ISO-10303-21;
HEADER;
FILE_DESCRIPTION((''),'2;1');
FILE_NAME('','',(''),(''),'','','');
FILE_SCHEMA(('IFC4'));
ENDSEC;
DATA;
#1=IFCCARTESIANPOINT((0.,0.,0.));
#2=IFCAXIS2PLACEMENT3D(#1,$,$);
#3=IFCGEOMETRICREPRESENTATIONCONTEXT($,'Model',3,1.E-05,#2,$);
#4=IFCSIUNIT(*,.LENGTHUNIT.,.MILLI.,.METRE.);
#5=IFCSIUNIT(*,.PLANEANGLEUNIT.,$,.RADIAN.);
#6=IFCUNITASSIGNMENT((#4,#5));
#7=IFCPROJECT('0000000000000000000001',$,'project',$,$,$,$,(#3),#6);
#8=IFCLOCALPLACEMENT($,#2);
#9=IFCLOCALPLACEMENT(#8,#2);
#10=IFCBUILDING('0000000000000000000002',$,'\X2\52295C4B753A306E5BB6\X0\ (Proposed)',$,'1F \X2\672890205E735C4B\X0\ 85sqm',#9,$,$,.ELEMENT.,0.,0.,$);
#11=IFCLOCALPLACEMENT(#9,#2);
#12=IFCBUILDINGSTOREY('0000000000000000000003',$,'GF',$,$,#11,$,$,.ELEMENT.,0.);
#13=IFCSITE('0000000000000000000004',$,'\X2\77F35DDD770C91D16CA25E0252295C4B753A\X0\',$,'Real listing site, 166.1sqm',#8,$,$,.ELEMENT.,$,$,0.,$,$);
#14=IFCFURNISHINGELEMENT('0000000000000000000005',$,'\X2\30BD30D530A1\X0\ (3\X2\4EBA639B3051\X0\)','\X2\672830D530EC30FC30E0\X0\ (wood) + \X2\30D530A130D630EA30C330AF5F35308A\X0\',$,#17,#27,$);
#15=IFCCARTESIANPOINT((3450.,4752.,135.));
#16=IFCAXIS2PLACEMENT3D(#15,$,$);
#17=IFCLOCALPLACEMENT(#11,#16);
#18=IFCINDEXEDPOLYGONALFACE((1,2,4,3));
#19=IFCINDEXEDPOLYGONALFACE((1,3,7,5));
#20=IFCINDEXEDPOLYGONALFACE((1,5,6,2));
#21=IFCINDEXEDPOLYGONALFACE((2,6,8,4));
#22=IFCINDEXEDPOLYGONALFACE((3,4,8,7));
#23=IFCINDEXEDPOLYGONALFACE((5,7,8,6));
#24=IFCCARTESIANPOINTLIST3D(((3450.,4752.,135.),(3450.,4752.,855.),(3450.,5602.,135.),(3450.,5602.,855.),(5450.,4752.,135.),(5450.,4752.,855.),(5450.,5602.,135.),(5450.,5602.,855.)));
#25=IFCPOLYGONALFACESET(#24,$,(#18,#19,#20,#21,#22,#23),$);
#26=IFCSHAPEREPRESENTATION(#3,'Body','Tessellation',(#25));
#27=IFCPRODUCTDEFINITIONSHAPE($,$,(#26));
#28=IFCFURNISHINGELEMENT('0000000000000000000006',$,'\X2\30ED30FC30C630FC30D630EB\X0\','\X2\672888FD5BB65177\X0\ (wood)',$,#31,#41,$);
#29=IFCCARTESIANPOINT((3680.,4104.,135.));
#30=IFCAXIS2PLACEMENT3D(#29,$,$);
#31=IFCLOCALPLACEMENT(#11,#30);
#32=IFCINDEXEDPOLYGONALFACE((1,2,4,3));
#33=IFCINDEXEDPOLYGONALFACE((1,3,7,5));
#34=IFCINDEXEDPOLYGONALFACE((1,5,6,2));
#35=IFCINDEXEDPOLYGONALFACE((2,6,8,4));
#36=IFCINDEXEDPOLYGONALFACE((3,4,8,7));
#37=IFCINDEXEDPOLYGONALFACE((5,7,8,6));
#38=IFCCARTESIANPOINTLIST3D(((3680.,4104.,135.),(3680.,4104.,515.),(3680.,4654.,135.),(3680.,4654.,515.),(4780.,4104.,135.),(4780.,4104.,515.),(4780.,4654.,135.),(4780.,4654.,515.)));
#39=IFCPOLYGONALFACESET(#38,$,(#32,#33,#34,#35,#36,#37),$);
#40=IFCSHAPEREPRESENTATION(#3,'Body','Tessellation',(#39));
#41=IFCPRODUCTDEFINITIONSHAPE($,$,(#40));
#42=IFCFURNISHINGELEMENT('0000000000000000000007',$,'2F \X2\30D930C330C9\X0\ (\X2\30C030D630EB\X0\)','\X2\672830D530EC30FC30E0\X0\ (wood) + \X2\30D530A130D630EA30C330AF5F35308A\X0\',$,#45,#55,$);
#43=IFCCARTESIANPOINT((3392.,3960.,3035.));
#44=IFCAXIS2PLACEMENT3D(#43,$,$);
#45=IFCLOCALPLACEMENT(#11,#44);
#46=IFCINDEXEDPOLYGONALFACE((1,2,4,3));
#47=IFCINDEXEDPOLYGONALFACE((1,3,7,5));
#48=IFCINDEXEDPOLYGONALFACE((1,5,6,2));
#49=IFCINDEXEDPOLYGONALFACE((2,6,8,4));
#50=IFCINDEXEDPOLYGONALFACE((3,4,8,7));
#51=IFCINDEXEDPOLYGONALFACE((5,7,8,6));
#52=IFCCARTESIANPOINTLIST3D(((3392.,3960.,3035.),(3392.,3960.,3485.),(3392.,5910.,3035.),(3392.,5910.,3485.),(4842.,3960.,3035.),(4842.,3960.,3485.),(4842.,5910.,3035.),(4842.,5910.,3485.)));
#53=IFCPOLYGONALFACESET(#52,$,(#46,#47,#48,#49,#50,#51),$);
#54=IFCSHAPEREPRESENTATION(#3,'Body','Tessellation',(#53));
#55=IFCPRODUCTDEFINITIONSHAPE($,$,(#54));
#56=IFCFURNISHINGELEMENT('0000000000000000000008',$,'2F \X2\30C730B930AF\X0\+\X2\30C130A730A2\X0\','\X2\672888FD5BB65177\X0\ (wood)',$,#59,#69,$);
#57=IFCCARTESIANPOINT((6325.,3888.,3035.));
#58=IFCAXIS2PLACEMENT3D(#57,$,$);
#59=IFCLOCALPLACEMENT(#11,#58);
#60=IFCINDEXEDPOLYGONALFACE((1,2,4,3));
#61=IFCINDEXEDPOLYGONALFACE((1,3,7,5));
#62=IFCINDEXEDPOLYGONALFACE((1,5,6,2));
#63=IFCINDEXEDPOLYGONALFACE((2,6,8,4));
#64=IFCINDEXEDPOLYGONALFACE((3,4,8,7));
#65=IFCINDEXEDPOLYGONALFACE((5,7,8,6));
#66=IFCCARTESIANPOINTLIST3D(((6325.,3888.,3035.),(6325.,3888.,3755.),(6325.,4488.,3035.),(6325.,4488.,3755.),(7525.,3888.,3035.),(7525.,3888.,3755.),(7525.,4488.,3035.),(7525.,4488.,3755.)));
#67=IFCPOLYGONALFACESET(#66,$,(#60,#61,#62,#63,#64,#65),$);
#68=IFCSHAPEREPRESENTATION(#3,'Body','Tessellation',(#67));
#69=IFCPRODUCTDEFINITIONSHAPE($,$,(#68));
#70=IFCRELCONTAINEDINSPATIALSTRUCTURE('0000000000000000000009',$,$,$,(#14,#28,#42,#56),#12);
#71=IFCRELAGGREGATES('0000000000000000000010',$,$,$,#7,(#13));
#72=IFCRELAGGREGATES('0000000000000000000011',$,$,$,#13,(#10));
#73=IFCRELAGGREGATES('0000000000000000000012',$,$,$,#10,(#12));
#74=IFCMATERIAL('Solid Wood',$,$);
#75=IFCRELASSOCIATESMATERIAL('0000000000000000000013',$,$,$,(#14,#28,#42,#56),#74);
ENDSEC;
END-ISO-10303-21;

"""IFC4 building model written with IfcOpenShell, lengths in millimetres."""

from ifc_helpers import new_model, si_unit, frame, frame_2d, origin, place, context, project, spatial, rectangle, extrude, material, element, save


model = new_model("IFC4")

# Units and contexts
model_context = context("Model", 3, precision=1e-05, world=origin())
ifc_project = project(units=[si_unit("LENGTHUNIT", "METRE", prefix="MILLI"), si_unit("PLANEANGLEUNIT", "RADIAN")], contexts=[model_context])

# Site, building, storey
site_placement = place(None, origin())
site = spatial("IfcSite", under=ifc_project, at=site_placement, Name="石川県金沢市利屋町", ObjectType="Real listing site, 166.1sqm", CompositionType="ELEMENT", RefElevation=0.0)
building_placement = place(site_placement, origin())
building = spatial("IfcBuilding", under=site, at=building_placement, Name="利屋町の家 (Proposed)", ObjectType="1F 木造平屋 85sqm", CompositionType="ELEMENT", ElevationOfRefHeight=0.0, ElevationOfTerrain=0.0)
storey_placement = place(building_placement, origin())
storey = spatial("IfcBuildingStorey", under=building, at=storey_placement, Name="GF", CompositionType="ELEMENT", Elevation=0.0)

# Shared definitions
ifc_material_1 = material(Name="Solid Wood")

# Furnishing elements
furnishing_1_placement = place(storey_placement, frame((3450.0, 4752.0, 135.0)))
element("IfcFurnishingElement", 1, at=furnishing_1_placement, inside=storey, material=ifc_material_1, Name="ソファ (3人掛け)", Description="木フレーム (wood) + ファブリック張り", context=model_context, shape_type="SweptSolid", body=[
    extrude(rectangle(XDim=2000.0, YDim=850.0, at=frame_2d((1000.0, 425.0))), frame((3450.0, 4752.0, 135.0)), (0.0, 0.0, 1.0), 720.0),
])
furnishing_2_placement = place(storey_placement, frame((3680.0, 4104.0, 135.0)))
element("IfcFurnishingElement", 2, at=furnishing_2_placement, inside=storey, material=ifc_material_1, Name="ローテーブル", Description="木製家具 (wood)", context=model_context, shape_type="SweptSolid", body=[
    extrude(rectangle(XDim=1100.0, YDim=550.0, at=frame_2d((550.0, 275.0))), frame((3680.0, 4104.0, 135.0)), (0.0, 0.0, 1.0), 380.0),
])
furnishing_3_placement = place(storey_placement, frame((3392.0, 3960.0, 3035.0)))
element("IfcFurnishingElement", 3, at=furnishing_3_placement, inside=storey, material=ifc_material_1, Name="2F ベッド (ダブル)", Description="木フレーム (wood) + ファブリック張り", context=model_context, shape_type="SweptSolid", body=[
    extrude(rectangle(XDim=1450.0, YDim=1950.0, at=frame_2d((725.0, 975.0))), frame((3392.0, 3960.0, 3035.0)), (0.0, 0.0, 1.0), 450.0),
])
furnishing_4_placement = place(storey_placement, frame((6325.0, 3888.0, 3035.0)))
element("IfcFurnishingElement", 4, at=furnishing_4_placement, inside=storey, material=ifc_material_1, Name="2F デスク+チェア", Description="木製家具 (wood)", context=model_context, shape_type="SweptSolid", body=[
    extrude(rectangle(XDim=1200.0, YDim=600.0, at=frame_2d((600.0, 300.0))), frame((6325.0, 3888.0, 3035.0)), (0.0, 0.0, 1.0), 720.0),
])

save(model, "model.ifc")
